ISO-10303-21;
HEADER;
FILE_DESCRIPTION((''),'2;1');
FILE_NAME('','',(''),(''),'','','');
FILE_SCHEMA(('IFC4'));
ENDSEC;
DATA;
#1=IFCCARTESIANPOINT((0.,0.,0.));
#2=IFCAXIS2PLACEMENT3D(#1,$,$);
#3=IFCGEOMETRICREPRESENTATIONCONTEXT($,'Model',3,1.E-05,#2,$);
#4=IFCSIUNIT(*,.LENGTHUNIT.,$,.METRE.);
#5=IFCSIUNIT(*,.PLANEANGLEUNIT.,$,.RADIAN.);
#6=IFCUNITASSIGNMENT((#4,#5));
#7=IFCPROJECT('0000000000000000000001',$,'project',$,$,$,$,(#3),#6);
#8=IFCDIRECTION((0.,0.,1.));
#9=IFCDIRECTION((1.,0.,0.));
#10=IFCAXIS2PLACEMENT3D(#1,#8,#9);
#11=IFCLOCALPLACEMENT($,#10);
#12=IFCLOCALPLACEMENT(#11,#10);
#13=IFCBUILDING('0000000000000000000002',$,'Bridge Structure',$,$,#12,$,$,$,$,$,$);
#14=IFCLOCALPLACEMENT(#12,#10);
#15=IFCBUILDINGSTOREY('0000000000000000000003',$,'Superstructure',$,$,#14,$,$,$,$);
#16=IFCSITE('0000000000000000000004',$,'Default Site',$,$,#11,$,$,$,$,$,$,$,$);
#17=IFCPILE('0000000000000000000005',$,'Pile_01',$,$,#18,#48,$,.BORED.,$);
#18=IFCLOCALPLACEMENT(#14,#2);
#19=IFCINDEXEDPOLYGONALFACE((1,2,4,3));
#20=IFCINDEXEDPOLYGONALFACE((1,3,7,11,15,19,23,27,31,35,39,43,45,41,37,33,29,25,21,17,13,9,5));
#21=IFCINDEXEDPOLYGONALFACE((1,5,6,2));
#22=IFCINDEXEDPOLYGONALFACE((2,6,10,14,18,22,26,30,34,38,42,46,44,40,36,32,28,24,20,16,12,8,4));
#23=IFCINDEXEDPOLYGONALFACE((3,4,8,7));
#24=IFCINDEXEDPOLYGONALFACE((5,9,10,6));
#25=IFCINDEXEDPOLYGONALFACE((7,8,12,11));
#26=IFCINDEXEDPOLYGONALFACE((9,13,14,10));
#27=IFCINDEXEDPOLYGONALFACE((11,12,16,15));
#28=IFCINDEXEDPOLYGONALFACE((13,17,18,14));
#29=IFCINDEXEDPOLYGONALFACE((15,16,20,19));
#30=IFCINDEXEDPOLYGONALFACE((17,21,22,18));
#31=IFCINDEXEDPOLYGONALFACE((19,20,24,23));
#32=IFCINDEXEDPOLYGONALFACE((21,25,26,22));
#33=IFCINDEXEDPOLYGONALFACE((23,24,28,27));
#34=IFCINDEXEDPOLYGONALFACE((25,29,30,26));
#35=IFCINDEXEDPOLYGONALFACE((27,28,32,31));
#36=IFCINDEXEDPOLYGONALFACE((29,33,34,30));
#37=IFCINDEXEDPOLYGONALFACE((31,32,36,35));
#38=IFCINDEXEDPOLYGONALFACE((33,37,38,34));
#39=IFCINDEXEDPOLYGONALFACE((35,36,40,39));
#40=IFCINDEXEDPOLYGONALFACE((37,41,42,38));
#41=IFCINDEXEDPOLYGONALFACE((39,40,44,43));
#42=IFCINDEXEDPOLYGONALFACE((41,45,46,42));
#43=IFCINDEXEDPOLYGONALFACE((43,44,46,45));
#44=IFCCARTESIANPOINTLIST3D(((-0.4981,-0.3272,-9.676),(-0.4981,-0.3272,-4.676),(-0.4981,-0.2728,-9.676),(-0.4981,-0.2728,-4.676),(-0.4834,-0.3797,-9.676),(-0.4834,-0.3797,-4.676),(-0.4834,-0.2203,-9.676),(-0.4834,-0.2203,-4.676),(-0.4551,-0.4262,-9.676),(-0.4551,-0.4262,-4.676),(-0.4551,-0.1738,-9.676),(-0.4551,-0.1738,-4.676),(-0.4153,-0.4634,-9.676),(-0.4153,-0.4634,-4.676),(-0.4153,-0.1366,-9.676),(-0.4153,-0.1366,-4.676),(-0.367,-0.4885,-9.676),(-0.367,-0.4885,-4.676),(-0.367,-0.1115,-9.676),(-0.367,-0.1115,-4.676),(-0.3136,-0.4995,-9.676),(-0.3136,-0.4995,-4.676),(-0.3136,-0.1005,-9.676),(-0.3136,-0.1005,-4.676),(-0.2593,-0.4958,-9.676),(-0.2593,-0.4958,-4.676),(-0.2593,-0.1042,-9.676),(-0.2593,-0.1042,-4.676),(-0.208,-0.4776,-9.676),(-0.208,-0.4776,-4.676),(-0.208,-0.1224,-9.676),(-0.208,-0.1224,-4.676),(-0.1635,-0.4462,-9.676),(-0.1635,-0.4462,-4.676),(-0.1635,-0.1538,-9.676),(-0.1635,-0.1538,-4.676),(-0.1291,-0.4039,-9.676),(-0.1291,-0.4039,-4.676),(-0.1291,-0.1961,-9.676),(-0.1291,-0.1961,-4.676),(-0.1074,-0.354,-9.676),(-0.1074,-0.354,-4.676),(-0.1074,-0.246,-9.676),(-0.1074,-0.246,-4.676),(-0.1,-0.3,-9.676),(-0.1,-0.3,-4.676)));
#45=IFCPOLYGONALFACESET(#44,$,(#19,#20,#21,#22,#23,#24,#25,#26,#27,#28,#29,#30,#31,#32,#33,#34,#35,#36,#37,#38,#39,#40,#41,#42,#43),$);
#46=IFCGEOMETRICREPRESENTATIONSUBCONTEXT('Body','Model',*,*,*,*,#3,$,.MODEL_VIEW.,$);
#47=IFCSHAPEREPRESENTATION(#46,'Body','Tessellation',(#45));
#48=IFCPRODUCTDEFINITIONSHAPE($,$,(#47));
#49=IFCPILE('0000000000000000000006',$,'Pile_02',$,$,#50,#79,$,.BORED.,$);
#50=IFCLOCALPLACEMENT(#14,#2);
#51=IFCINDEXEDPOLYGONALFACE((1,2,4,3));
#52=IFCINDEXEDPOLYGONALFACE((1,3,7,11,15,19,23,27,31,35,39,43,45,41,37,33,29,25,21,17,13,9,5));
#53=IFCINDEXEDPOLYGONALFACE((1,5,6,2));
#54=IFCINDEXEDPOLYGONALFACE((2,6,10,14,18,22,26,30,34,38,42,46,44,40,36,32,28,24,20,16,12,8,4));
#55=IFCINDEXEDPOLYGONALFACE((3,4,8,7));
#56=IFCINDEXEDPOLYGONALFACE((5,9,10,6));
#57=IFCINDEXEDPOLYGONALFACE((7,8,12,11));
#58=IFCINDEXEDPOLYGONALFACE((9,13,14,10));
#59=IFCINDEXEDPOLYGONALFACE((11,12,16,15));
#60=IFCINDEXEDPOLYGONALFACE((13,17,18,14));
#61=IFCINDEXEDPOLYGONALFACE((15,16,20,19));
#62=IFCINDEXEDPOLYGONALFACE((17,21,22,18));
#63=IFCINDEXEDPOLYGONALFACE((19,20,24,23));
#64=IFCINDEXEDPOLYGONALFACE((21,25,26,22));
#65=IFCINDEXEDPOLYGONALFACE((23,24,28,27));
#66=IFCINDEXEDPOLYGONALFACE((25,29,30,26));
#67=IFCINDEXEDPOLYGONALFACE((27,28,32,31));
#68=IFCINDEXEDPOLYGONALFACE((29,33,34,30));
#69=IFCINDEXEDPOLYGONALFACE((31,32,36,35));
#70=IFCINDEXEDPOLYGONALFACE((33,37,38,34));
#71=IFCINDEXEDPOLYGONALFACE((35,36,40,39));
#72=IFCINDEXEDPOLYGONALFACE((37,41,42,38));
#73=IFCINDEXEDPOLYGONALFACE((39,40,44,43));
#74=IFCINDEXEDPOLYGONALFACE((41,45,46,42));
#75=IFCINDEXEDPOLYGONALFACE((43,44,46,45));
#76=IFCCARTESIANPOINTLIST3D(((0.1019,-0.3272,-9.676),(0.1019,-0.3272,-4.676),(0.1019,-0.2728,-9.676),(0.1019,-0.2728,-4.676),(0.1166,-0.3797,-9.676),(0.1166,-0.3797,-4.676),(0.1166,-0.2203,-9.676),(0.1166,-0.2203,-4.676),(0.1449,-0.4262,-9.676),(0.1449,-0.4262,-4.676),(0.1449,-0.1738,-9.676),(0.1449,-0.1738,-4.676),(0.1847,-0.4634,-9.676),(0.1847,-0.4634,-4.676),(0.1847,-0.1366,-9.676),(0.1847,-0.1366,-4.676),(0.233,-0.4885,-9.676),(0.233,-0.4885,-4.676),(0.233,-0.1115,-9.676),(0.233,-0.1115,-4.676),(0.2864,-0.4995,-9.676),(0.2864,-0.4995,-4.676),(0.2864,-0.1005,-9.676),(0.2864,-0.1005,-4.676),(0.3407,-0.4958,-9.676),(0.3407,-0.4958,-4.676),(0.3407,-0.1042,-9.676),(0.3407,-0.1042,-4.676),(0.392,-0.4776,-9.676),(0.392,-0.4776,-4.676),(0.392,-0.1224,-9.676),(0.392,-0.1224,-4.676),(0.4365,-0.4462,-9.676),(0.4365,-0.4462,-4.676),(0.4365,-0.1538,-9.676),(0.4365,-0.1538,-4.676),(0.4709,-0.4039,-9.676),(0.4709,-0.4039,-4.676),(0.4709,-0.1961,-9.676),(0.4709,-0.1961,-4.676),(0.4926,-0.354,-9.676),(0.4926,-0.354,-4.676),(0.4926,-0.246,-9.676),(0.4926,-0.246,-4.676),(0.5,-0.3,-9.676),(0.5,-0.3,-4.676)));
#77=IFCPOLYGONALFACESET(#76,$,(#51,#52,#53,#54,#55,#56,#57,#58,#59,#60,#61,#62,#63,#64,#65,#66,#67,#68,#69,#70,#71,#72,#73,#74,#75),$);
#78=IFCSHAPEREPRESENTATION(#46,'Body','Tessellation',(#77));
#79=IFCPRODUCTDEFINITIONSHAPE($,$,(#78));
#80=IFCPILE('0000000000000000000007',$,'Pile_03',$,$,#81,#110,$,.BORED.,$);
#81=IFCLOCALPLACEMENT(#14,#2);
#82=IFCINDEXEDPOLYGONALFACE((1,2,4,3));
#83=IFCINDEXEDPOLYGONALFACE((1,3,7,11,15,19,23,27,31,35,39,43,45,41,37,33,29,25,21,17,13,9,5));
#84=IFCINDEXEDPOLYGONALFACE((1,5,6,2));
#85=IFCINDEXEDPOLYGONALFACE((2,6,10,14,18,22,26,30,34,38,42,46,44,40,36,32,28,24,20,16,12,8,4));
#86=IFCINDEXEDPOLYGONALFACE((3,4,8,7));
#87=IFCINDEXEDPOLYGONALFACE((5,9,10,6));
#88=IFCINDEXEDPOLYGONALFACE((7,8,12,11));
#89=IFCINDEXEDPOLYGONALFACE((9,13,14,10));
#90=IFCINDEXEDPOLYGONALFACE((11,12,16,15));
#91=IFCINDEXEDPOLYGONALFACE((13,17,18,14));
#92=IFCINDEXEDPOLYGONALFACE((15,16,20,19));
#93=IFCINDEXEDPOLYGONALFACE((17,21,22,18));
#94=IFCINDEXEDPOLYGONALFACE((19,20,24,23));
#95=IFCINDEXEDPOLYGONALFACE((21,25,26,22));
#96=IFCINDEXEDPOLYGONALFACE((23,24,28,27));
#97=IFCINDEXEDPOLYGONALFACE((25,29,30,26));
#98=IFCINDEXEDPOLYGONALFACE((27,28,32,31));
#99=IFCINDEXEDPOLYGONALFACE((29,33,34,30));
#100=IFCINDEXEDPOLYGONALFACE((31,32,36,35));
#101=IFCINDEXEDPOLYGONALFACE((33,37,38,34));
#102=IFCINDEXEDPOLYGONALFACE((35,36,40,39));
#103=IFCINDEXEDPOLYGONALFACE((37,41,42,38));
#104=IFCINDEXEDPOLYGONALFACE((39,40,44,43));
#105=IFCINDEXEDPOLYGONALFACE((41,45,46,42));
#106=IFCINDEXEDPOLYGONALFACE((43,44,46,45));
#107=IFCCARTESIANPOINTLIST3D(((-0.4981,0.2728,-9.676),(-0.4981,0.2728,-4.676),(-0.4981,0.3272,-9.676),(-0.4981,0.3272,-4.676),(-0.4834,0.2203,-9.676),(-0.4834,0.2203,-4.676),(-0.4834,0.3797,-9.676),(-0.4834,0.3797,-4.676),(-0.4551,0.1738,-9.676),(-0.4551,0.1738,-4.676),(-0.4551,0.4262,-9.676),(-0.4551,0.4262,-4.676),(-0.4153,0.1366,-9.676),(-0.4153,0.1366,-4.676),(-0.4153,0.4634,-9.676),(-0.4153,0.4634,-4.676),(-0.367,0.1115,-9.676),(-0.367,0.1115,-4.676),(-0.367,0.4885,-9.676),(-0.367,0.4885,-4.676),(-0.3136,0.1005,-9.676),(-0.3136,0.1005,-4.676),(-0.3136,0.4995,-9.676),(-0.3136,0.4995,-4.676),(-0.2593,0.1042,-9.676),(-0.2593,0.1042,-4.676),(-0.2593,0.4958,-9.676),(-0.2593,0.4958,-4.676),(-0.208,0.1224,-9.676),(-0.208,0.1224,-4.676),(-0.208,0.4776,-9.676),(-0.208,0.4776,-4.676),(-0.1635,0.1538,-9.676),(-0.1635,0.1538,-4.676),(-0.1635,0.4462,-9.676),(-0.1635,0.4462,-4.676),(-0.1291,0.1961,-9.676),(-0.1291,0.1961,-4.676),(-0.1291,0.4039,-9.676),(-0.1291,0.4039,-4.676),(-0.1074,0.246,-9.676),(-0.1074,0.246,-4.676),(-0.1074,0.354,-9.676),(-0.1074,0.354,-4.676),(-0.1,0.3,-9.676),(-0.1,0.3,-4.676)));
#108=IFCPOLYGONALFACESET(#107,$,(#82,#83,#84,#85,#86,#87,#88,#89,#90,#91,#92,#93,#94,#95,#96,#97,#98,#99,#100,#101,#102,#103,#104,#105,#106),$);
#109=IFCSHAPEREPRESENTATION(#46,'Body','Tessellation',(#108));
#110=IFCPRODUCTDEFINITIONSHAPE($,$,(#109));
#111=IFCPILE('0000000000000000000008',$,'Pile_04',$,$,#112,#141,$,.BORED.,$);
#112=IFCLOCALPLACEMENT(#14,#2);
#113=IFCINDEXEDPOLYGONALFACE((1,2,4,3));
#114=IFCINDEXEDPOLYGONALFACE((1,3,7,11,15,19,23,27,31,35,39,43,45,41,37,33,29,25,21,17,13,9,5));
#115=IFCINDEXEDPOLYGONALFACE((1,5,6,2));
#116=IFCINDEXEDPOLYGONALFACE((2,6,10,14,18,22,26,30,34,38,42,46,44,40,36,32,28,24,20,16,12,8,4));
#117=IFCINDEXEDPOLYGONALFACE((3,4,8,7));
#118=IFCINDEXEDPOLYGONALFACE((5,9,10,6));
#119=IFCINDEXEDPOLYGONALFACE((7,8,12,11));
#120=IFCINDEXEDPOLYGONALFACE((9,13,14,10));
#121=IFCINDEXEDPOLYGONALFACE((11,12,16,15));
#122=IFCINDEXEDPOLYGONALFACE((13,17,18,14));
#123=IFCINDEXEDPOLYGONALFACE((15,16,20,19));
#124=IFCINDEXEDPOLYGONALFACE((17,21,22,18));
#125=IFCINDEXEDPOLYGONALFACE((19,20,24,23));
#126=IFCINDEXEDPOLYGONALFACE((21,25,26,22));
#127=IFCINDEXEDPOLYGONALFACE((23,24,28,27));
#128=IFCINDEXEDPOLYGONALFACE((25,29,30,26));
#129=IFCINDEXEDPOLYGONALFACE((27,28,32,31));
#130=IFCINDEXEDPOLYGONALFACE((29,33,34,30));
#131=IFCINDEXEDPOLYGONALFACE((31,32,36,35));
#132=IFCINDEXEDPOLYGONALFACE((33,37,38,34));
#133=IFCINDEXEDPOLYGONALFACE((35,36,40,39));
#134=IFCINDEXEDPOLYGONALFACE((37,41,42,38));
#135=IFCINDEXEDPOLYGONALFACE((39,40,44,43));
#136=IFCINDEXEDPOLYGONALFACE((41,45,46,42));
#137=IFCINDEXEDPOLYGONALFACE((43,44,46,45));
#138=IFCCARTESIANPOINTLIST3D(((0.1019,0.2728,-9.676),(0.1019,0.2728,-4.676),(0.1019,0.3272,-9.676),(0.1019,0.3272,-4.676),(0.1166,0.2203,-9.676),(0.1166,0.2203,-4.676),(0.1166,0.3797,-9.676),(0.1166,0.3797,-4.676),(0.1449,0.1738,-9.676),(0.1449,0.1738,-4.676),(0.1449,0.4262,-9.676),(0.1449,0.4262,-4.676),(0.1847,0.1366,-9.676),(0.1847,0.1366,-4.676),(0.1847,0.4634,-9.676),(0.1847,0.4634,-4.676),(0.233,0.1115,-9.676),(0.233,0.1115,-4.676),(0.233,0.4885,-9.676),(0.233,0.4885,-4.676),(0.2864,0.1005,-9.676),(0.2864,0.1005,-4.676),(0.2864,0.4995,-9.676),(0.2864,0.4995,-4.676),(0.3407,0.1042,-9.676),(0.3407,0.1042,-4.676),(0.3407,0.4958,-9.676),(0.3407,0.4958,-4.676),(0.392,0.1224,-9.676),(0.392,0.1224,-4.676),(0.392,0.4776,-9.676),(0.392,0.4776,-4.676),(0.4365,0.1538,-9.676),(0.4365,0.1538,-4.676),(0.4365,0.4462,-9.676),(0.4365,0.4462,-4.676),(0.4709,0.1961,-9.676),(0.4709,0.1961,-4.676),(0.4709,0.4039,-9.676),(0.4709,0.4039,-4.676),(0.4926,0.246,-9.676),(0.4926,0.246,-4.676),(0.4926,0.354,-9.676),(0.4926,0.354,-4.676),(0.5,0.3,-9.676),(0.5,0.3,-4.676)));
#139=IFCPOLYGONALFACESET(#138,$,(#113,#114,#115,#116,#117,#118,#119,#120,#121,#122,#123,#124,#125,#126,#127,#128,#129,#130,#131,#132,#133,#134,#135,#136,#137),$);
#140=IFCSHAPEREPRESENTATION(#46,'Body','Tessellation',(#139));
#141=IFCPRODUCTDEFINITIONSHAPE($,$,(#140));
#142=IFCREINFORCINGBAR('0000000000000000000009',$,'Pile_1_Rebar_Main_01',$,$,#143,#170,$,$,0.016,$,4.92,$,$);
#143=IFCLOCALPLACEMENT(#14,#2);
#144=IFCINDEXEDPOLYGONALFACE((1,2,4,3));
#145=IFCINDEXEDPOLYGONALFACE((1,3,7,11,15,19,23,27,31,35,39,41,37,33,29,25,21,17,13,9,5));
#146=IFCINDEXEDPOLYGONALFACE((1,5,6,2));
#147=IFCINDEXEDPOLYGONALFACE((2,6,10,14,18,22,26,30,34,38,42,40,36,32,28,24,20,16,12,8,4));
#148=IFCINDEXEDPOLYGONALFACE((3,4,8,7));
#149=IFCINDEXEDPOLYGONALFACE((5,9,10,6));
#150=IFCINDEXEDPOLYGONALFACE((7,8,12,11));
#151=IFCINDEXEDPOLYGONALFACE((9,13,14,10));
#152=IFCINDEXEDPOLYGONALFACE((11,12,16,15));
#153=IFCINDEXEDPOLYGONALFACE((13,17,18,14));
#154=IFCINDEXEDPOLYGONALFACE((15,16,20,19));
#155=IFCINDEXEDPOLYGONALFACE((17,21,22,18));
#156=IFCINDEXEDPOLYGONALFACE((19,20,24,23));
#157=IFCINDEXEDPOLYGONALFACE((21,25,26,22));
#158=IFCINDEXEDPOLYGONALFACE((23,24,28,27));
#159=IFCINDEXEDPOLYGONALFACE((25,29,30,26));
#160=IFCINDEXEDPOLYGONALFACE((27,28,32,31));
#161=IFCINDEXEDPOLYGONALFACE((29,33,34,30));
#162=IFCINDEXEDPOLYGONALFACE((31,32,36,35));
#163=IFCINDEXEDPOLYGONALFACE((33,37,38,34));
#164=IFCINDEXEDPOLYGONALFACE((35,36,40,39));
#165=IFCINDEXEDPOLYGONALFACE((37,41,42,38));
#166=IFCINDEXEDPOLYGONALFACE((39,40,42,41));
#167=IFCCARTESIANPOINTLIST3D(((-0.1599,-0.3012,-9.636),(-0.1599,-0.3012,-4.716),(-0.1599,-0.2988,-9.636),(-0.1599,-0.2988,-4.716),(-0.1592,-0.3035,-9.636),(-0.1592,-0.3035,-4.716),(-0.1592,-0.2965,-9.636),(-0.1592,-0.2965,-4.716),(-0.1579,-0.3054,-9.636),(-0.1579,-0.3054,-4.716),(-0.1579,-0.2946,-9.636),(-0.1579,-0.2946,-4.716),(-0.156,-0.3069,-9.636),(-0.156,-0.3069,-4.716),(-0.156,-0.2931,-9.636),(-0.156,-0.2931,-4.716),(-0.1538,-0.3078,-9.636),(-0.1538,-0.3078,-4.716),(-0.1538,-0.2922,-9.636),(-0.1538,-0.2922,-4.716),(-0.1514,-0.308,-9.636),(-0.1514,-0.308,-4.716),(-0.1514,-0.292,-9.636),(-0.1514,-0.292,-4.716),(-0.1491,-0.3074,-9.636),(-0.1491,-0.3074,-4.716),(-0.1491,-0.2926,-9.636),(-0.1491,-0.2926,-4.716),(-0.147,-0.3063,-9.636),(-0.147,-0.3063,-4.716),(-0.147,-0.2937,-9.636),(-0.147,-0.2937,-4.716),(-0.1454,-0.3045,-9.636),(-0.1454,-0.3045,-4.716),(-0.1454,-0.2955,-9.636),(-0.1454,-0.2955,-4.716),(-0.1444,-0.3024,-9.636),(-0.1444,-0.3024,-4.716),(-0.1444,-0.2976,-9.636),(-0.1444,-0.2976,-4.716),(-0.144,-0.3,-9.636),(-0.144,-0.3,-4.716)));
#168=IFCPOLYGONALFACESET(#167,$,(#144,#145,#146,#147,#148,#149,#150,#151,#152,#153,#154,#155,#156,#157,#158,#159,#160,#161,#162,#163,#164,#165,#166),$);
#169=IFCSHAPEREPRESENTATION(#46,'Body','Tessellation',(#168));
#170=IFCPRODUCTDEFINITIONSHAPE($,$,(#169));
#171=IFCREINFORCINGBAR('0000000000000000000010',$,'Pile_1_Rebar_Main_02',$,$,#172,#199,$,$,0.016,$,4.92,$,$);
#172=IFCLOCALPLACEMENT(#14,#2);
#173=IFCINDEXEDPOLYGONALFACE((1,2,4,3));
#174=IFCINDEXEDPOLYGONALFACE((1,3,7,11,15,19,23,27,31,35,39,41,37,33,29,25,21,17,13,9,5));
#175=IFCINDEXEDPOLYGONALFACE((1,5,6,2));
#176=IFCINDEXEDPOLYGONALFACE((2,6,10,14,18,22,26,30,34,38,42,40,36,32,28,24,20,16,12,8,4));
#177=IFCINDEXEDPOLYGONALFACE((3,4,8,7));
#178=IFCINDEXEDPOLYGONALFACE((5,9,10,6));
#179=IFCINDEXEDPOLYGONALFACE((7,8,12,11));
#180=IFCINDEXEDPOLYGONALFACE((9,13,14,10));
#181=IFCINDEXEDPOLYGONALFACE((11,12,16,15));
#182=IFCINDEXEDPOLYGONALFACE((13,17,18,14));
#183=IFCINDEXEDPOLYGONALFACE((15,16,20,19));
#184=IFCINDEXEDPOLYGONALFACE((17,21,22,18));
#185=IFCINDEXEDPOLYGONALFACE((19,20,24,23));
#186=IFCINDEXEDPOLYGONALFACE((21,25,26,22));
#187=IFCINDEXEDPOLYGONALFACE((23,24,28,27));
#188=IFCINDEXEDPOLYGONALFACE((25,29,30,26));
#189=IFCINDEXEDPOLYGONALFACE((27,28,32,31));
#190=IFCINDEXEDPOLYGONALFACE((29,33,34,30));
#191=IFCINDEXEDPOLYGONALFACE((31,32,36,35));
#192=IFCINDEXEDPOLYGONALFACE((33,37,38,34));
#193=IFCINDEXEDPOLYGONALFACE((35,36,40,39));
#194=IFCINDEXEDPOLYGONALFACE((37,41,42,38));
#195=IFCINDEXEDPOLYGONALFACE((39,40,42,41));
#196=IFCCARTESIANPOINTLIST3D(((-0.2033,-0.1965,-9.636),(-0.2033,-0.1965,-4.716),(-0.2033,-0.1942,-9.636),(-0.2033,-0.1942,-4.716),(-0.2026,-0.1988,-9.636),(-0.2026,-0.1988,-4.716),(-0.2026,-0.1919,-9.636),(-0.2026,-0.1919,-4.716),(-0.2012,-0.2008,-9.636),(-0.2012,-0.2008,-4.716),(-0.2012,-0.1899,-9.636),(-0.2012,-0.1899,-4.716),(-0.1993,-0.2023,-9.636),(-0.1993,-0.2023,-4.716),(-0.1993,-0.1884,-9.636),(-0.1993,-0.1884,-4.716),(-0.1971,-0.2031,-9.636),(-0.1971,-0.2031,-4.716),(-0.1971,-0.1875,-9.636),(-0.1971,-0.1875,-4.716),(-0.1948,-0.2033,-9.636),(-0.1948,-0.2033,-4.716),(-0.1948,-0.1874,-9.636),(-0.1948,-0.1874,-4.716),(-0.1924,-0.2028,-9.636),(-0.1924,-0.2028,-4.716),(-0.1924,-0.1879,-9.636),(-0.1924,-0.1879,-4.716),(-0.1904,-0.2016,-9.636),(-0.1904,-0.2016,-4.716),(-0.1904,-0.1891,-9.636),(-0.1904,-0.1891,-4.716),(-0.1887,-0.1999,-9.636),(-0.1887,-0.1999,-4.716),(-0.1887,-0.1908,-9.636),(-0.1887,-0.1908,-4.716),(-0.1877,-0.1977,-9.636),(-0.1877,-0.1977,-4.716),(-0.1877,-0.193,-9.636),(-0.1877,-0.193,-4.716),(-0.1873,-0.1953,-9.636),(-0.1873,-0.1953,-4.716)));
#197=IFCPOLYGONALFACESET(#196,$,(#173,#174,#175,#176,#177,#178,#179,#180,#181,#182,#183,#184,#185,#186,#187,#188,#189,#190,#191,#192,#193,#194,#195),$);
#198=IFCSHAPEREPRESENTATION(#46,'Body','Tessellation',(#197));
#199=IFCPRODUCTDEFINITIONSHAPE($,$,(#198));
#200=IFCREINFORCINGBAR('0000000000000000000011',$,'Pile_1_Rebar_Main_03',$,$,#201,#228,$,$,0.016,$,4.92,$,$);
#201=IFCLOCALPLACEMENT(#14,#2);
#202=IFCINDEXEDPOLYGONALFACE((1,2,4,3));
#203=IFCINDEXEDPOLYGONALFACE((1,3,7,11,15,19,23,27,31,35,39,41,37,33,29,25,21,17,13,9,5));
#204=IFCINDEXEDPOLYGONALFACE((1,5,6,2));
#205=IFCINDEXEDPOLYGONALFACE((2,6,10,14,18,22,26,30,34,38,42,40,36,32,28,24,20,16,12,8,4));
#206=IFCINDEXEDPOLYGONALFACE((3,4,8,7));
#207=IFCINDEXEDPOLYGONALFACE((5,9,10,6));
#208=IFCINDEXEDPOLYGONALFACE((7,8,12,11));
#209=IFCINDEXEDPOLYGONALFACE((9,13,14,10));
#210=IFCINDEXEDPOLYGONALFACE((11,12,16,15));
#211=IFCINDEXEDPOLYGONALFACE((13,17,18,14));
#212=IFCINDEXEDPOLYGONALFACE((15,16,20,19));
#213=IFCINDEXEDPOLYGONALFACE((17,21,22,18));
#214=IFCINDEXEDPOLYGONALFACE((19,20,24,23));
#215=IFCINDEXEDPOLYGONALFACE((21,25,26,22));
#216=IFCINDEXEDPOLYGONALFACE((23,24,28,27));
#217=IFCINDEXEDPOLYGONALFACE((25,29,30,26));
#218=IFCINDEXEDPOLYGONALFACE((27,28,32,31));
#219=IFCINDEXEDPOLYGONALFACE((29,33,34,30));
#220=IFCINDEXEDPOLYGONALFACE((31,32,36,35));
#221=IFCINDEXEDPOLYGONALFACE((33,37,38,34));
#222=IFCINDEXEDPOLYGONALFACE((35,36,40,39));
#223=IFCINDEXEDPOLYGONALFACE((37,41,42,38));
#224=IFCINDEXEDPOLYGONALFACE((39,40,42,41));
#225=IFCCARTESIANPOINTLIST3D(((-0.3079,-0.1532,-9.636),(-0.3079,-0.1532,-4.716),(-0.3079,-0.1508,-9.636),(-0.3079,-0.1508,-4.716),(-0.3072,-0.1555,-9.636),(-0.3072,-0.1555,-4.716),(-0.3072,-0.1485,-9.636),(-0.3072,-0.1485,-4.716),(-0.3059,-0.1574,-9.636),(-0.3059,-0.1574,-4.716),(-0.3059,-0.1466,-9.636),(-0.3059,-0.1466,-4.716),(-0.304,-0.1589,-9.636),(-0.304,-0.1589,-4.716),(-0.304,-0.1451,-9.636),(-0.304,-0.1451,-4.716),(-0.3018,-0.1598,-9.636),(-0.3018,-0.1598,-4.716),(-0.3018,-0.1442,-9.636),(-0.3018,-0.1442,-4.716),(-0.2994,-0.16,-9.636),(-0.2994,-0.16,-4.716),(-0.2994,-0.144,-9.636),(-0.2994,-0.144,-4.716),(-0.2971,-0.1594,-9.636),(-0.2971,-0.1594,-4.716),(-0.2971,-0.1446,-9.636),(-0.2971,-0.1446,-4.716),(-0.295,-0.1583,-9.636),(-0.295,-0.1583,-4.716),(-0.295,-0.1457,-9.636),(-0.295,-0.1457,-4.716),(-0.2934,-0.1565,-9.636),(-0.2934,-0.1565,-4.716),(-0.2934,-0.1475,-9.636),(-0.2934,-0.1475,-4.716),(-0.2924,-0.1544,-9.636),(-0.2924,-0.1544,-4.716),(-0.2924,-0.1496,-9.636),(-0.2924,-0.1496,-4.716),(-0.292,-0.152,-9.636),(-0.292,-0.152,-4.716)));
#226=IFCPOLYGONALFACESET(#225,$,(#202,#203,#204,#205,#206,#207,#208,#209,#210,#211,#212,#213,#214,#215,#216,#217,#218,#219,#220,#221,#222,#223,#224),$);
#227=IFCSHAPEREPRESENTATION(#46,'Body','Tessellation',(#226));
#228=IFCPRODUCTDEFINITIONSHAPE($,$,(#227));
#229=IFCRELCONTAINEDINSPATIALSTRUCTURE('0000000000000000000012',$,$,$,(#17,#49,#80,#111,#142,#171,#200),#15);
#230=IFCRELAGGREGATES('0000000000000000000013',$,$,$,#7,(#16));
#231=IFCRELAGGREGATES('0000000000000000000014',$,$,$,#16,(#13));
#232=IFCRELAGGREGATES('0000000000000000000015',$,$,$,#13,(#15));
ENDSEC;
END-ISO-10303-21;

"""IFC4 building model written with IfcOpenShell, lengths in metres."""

from ifc_helpers import new_model, si_unit, frame, origin, origin_with_axes, origin_2d_with_axis, place, context, subcontext, project, spatial, circle, extrude, element, save


model = new_model("IFC4")

# Units and contexts
model_context = context("Model", 3, precision=1e-05, world=origin())
body_context = subcontext(model_context, "Body", "Model", "MODEL_VIEW")
ifc_project = project(units=[si_unit("LENGTHUNIT", "METRE"), si_unit("PLANEANGLEUNIT", "RADIAN")], contexts=[model_context])

# Site, building, storey
site_placement = place(None, origin_with_axes())
site = spatial("IfcSite", under=ifc_project, at=site_placement, Name="Default Site")
building_placement = place(site_placement, origin_with_axes())
building = spatial("IfcBuilding", under=site, at=building_placement, Name="Bridge Structure")
storey_placement = place(building_placement, origin_with_axes())
storey = spatial("IfcBuildingStorey", under=building, at=storey_placement, Name="Superstructure")

# Piles
for number, where, z_axis, x_axis, name in (
    (1, (-0.3, -0.3, -9.676), (0.0, 0.0, 1.0), (1.0, 0.0, 0.0), "Pile_01"),
    (2, (0.3, -0.3, -9.676), (0.0, 0.0, 1.0), (1.0, 0.0, 0.0), "Pile_02"),
    (3, (-0.3, 0.3, -9.676), (0.0, 0.0, 1.0), (1.0, 0.0, 0.0), "Pile_03"),
    (4, (0.3, 0.3, -9.676), (0.0, 0.0, 1.0), (1.0, 0.0, 0.0), "Pile_04"),
):
    element("IfcPile", number, at=place(storey_placement, frame(where, z_axis=z_axis, x_axis=x_axis)), inside=storey, Name=name, PredefinedType="BORED", context=body_context, shape_type="SweptSolid", body=[
        extrude(circle(Radius=0.2, at=origin_2d_with_axis()), origin_with_axes(), (0.0, 0.0, 1.0), 5.0),
    ])

# Reinforcing bars
for number, where, z_axis, x_axis, name in (
    (5, (-0.152, -0.3, -9.636), (0.0, 0.0, 1.0), (1.0, 0.0, 0.0), "Pile_1_Rebar_Main_01"),
    (6, (-0.1953, -0.1953, -9.636), (0.0, 0.0, 1.0), (1.0, 0.0, 0.0), "Pile_1_Rebar_Main_02"),
    (7, (-0.3, -0.152, -9.636), (0.0, 0.0, 1.0), (1.0, 0.0, 0.0), "Pile_1_Rebar_Main_03"),
):
    element("IfcReinforcingBar", number, at=place(storey_placement, frame(where, z_axis=z_axis, x_axis=x_axis)), inside=storey, Name=name, BarLength=4.92, NominalDiameter=0.016, context=body_context, shape_type="SweptSolid", body=[
        extrude(circle(Radius=0.008, at=origin_2d_with_axis()), origin_with_axes(), (0.0, 0.0, 1.0), 4.92),
    ])

save(model, "model.ifc")
